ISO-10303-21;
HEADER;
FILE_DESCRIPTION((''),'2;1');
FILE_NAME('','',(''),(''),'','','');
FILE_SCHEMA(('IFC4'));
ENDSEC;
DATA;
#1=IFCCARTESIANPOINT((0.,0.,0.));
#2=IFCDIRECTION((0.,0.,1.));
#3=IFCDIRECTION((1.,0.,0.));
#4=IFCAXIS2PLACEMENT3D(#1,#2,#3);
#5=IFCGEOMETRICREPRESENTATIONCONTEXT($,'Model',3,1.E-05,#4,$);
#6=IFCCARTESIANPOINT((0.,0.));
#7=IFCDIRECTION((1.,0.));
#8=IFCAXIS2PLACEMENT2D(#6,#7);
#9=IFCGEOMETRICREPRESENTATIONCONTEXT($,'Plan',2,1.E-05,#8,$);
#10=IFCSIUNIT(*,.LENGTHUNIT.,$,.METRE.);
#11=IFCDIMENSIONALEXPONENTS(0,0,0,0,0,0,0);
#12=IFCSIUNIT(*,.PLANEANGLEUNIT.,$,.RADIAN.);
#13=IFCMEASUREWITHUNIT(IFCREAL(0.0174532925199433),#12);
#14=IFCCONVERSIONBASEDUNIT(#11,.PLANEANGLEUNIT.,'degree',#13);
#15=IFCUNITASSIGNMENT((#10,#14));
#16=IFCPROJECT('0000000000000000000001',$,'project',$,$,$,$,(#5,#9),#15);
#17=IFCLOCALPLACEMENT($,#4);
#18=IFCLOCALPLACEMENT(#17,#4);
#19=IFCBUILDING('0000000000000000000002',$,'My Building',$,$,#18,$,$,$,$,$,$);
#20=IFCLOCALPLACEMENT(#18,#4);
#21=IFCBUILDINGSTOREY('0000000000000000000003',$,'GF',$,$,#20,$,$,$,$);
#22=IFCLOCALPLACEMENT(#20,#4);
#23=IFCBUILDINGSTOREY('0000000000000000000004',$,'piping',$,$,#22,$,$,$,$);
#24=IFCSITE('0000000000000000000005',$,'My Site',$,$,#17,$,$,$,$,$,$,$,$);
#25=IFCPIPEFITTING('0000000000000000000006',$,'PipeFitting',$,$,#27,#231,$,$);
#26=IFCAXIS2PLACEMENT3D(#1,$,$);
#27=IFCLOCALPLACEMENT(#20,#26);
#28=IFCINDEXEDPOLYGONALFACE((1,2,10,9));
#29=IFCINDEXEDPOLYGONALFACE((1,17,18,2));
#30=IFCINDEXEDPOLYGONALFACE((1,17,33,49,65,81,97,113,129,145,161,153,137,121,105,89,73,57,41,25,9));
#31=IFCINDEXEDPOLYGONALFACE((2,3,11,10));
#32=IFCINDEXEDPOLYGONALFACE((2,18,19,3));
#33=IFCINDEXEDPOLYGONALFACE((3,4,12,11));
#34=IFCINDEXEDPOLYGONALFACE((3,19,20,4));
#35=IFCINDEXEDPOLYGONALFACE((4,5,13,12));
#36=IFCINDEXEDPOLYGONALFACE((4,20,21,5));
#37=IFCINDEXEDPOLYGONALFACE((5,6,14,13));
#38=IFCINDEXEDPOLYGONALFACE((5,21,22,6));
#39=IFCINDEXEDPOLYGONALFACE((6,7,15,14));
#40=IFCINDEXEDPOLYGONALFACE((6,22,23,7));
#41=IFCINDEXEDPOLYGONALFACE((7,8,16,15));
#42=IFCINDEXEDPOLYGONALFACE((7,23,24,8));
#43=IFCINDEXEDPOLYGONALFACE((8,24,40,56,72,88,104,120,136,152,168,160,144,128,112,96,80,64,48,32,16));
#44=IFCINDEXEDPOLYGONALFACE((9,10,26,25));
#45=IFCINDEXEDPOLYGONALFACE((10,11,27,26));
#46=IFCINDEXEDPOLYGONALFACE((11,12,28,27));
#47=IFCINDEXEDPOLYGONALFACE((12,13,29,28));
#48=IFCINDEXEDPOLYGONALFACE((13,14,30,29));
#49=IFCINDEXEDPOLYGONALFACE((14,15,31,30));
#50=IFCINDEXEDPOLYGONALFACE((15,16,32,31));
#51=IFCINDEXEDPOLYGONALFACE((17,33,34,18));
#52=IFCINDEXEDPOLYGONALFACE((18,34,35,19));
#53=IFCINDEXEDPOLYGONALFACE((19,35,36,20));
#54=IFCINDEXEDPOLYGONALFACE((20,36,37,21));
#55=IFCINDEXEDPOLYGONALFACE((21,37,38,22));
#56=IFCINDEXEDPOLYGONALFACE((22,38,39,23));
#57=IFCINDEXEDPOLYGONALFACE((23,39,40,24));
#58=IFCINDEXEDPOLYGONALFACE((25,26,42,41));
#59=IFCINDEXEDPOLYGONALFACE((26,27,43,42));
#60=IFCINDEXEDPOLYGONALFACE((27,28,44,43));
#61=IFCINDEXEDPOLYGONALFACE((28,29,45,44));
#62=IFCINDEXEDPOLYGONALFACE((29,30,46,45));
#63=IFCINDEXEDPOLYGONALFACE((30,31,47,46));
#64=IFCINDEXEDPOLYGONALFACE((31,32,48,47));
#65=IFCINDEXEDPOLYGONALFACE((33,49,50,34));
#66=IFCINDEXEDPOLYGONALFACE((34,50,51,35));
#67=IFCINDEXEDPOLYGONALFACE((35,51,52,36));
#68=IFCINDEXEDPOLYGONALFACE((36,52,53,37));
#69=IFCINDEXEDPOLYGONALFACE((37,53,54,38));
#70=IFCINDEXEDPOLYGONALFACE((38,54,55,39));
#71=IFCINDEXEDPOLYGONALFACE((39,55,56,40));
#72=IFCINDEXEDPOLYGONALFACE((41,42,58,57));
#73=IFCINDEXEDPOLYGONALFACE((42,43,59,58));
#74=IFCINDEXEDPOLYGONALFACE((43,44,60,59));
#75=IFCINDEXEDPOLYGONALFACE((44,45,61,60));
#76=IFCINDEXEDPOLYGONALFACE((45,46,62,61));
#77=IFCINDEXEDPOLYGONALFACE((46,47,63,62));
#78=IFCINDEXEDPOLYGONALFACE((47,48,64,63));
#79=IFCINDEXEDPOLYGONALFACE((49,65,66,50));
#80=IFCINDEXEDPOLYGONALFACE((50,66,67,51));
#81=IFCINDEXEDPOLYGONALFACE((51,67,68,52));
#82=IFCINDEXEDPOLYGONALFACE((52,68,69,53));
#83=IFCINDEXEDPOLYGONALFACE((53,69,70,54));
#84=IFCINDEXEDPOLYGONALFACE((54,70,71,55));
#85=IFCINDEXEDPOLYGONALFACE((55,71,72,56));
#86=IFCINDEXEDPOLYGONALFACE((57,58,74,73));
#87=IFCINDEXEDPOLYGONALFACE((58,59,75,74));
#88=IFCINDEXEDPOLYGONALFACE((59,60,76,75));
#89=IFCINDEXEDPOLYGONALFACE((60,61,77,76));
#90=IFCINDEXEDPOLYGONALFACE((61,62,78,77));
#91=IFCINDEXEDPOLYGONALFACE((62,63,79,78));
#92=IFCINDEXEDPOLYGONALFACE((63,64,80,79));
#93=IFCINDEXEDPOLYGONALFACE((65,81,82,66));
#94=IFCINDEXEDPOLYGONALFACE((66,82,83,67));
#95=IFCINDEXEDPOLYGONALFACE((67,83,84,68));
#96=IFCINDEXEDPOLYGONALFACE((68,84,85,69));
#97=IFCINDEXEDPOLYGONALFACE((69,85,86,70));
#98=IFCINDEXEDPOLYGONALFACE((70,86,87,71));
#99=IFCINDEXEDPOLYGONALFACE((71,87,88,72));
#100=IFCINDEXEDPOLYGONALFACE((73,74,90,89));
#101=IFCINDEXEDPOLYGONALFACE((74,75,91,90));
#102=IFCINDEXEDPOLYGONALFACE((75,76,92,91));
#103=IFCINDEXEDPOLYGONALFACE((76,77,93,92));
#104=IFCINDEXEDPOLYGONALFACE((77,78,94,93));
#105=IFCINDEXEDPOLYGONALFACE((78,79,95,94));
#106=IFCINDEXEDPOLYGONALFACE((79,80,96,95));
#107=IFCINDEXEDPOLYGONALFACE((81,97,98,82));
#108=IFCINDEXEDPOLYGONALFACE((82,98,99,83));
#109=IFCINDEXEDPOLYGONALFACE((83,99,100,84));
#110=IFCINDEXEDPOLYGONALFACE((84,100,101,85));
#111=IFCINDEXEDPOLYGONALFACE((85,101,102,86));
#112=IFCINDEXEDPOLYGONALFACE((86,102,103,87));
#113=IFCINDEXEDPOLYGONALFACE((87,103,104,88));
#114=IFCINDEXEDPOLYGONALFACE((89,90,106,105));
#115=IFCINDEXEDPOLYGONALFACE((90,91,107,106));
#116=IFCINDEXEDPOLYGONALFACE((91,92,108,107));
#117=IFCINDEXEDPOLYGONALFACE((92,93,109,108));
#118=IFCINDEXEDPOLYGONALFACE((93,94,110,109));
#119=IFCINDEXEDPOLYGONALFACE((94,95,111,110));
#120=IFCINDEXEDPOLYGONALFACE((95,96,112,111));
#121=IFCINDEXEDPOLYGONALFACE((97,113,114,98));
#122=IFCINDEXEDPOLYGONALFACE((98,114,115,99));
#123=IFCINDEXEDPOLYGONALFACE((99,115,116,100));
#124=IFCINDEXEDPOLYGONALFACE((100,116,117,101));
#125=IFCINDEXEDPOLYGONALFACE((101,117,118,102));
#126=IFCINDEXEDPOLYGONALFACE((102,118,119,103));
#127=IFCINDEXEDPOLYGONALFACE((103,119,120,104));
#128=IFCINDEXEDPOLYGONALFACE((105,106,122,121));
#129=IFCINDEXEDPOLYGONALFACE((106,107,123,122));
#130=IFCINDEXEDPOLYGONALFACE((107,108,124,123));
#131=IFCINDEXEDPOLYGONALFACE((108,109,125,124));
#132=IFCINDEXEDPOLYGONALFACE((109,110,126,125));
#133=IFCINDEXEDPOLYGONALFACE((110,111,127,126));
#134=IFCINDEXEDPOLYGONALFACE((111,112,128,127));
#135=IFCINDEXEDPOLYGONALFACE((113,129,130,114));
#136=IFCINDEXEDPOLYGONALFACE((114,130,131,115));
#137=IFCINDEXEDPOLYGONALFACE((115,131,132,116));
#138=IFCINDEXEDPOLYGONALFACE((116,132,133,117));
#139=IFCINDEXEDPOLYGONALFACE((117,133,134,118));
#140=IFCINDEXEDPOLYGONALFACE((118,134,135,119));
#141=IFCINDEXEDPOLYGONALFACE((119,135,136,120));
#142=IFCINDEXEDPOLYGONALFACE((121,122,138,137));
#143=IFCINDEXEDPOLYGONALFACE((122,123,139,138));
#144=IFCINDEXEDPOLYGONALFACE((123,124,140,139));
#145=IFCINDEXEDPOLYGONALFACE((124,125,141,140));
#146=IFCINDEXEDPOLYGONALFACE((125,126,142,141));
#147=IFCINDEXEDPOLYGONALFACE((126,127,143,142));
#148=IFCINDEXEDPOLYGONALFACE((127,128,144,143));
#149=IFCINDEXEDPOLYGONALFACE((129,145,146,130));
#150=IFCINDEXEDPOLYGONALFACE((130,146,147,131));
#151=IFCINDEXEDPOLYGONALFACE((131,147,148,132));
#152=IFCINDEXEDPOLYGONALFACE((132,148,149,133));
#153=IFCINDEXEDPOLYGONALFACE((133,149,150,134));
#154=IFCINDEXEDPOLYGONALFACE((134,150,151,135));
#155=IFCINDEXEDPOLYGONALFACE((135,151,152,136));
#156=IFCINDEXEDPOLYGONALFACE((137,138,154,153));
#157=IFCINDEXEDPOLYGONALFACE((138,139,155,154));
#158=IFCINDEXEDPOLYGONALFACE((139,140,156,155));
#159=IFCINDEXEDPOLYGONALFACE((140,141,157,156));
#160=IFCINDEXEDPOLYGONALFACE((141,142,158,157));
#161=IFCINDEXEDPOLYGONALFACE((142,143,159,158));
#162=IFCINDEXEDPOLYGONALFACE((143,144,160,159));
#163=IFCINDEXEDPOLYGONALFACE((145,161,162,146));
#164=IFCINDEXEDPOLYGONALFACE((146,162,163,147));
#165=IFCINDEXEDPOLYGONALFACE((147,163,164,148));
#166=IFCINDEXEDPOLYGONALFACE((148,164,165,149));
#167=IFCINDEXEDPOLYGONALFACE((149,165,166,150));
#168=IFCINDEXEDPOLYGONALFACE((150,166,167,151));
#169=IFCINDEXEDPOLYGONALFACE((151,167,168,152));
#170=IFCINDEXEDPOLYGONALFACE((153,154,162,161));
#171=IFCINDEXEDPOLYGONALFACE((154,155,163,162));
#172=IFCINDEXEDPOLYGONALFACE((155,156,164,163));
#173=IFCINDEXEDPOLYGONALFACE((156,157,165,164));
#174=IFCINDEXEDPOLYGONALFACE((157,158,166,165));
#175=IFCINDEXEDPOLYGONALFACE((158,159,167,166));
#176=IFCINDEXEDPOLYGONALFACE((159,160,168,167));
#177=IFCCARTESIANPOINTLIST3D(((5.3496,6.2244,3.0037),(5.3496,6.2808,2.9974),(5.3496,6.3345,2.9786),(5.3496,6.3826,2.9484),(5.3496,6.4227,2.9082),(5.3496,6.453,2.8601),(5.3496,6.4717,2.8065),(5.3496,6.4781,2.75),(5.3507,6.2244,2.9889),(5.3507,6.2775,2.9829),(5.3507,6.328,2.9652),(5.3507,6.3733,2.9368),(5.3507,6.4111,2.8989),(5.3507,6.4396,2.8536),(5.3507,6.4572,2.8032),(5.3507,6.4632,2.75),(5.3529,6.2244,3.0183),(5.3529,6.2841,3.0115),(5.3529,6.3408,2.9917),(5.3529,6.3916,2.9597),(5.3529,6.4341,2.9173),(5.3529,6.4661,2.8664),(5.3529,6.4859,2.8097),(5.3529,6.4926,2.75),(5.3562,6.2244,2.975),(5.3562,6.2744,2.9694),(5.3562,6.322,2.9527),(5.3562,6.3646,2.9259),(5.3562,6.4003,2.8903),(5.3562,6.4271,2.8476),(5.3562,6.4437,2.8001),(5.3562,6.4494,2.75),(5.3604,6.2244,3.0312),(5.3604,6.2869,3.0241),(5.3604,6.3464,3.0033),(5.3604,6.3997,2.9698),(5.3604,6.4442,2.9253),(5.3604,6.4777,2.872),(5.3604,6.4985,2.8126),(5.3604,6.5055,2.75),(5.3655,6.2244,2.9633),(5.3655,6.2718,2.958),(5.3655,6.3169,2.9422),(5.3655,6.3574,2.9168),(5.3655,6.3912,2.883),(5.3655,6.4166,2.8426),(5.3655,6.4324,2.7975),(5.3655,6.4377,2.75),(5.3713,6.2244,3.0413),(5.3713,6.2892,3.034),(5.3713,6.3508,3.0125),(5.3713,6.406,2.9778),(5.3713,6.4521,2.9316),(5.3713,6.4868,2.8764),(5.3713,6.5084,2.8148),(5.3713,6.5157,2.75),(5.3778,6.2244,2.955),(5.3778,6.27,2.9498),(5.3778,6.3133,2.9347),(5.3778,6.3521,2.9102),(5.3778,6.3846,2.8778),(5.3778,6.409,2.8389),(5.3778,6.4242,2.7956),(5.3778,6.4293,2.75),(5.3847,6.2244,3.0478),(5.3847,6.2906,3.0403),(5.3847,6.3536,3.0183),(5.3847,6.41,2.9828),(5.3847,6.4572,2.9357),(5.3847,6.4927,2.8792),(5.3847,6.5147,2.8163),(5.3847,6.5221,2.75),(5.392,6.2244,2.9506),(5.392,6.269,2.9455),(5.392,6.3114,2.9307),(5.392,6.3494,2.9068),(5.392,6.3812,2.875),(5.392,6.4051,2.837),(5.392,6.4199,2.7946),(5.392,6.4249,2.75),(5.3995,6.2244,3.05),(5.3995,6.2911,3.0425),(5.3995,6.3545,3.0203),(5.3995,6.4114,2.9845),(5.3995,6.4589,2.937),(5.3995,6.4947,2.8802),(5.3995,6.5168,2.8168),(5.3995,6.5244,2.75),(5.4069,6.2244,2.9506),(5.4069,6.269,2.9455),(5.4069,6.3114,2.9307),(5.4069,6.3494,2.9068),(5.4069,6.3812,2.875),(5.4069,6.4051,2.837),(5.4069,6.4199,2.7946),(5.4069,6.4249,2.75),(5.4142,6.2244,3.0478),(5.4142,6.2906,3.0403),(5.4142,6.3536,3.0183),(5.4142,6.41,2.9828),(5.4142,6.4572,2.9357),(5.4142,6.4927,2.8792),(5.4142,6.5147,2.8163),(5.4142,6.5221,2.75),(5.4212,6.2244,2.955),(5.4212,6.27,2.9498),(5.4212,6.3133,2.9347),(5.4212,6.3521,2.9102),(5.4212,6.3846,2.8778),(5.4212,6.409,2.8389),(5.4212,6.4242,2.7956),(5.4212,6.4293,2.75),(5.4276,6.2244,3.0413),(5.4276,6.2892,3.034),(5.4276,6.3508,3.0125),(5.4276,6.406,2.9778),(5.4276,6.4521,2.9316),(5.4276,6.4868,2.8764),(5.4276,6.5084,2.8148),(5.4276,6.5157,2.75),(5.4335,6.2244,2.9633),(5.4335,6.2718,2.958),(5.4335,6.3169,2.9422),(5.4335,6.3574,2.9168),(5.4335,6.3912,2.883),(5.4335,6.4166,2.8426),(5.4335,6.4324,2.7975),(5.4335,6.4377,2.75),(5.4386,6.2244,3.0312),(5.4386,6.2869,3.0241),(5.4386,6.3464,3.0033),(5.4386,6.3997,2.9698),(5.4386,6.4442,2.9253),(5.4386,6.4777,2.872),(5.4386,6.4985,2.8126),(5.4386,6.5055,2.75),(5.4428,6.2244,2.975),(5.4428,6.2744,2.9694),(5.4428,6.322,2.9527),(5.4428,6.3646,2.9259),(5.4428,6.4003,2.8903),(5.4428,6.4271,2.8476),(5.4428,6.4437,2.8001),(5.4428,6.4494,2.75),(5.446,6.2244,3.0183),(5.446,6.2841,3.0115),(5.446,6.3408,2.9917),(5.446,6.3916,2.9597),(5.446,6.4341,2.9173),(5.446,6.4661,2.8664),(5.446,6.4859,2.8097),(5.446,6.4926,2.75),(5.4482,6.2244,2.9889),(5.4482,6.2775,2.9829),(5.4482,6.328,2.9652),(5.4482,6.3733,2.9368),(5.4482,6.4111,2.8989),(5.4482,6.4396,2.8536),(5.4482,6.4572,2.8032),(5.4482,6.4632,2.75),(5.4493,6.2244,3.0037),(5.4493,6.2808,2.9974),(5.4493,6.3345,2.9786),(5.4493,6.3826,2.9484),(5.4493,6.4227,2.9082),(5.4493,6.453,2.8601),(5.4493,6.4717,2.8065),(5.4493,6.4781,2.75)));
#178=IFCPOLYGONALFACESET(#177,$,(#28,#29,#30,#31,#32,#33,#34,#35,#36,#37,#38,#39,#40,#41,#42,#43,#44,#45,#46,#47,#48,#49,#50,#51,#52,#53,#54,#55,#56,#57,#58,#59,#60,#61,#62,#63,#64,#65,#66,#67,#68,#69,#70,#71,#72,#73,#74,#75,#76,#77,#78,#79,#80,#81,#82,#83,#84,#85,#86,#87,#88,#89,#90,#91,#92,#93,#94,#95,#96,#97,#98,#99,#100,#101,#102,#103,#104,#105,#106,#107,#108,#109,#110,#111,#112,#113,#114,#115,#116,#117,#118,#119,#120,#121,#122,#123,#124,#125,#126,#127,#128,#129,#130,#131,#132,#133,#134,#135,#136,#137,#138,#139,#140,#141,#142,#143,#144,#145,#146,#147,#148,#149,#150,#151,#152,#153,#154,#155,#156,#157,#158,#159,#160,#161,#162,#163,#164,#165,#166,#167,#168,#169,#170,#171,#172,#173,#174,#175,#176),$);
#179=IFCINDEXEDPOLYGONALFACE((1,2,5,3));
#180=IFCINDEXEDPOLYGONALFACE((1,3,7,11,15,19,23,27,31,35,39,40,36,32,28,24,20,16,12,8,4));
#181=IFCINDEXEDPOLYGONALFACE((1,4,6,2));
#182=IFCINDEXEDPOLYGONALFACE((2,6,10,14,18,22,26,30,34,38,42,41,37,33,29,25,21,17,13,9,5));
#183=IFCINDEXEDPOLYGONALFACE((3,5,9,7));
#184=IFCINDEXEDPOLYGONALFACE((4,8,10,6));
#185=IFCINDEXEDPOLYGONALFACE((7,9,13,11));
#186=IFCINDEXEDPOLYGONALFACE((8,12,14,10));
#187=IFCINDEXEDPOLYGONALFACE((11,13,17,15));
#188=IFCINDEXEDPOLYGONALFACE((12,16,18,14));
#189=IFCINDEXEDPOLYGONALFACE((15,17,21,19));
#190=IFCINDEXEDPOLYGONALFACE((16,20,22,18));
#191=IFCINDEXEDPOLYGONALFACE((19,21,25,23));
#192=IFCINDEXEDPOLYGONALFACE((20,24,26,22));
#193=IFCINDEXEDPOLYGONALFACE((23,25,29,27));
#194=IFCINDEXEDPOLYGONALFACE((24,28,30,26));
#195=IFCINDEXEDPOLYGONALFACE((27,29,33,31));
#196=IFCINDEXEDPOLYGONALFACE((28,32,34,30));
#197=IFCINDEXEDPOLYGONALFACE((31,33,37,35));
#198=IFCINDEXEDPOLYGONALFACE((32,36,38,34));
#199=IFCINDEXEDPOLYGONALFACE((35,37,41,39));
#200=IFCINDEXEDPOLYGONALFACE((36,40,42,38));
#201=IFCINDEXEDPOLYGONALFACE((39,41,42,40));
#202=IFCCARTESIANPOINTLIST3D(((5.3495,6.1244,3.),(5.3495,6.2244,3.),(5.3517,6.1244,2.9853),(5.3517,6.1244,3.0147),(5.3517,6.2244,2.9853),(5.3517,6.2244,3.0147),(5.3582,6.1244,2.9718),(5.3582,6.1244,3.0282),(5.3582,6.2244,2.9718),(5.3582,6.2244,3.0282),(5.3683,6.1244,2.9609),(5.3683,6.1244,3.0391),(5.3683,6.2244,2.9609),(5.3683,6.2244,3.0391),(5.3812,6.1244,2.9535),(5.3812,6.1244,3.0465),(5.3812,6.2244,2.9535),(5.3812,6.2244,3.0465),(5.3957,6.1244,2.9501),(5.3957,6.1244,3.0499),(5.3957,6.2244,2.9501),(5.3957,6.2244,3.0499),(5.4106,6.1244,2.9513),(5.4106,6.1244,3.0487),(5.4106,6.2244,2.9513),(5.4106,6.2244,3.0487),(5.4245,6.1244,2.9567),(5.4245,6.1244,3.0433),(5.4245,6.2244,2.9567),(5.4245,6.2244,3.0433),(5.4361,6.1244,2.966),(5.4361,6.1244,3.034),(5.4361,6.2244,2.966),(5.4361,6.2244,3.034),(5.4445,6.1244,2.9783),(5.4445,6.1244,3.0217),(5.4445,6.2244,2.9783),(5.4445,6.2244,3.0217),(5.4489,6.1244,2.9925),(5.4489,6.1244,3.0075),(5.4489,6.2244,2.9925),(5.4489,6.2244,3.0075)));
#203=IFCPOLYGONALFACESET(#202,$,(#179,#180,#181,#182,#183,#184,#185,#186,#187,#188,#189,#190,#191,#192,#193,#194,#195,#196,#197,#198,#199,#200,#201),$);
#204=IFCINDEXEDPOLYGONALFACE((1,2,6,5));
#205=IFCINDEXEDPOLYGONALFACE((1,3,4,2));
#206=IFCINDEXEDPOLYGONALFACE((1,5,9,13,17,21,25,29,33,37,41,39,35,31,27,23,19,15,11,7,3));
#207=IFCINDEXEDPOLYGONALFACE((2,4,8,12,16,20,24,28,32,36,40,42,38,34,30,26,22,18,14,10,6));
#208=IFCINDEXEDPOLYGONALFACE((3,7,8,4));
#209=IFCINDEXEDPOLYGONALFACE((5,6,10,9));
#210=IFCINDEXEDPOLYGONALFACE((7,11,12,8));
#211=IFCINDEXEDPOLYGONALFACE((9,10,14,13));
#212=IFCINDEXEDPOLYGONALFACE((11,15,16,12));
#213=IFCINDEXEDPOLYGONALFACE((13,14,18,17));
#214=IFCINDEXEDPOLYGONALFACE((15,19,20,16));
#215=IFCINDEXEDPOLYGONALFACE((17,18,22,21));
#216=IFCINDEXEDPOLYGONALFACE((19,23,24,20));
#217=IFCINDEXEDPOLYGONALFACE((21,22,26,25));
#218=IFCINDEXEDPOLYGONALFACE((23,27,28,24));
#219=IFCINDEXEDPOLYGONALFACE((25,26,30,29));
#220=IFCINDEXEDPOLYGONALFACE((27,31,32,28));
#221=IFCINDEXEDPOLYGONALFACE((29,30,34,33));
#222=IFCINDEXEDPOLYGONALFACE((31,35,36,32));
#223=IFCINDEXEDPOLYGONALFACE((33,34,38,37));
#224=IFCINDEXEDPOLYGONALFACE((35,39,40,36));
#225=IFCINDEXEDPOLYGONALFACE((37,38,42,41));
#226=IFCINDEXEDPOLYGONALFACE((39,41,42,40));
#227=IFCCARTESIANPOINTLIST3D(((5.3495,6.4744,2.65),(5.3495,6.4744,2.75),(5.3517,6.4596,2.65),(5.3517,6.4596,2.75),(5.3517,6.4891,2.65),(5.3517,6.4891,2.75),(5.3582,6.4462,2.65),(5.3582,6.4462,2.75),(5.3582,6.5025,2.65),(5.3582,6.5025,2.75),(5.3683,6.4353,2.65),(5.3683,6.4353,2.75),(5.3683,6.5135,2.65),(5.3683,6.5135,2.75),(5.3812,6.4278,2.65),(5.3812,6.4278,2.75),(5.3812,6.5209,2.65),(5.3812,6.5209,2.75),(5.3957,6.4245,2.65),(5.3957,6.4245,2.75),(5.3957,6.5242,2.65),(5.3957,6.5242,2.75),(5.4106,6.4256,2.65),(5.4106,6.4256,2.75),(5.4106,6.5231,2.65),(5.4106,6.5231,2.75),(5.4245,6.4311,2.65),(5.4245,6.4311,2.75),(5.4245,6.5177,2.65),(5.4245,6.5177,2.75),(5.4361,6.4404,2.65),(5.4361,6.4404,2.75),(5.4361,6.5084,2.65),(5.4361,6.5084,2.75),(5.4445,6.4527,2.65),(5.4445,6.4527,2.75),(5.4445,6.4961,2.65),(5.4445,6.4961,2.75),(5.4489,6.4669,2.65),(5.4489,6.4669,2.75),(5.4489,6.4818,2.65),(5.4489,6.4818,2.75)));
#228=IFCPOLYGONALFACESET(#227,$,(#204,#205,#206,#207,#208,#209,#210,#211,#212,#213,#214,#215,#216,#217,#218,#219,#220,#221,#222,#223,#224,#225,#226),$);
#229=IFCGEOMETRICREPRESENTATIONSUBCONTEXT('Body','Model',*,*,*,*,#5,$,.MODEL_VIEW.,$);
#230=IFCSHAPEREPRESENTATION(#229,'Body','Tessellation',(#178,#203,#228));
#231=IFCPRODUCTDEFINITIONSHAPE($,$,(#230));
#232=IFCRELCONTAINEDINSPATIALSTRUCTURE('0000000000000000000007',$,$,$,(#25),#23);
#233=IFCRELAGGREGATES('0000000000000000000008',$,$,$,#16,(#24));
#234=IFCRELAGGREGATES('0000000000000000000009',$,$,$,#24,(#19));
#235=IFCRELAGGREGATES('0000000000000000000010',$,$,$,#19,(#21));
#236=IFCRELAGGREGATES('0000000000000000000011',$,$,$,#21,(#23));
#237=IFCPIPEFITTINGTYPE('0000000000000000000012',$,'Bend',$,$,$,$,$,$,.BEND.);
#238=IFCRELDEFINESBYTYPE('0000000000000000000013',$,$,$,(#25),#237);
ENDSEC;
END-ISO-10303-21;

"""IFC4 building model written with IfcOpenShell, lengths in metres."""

from ifc_helpers import new_model, entity, si_unit, converted_unit, frame, origin_with_axes, origin_2d_with_axis, place, context, subcontext, project, spatial, circle, extrude, source, transform, mapped, type_object, type_shapes, element, save


model = new_model("IFC4")

# Units and contexts
model_context = context("Model", 3, precision=1e-05, world=origin_with_axes())
plan_context = context("Plan", 2, precision=1e-05, world=origin_2d_with_axis())
body_context = subcontext(model_context, "Body", "Model", "MODEL_VIEW")
ifc_project = project(units=[si_unit("LENGTHUNIT", "METRE"), converted_unit("PLANEANGLEUNIT", "degree", entity("IfcReal", 0.0174532925199433), si_unit("PLANEANGLEUNIT", "RADIAN"), dimensions=[0, 0, 0, 0, 0, 0, 0])], contexts=[model_context, plan_context])

# Site, building, storeys
site_placement = place(None, origin_with_axes())
site = spatial("IfcSite", under=ifc_project, at=site_placement, Name="My Site")
building_placement = place(site_placement, origin_with_axes())
building = spatial("IfcBuilding", under=site, at=building_placement, Name="My Building")
storey_1_placement = place(building_placement, origin_with_axes())
storey_1 = spatial("IfcBuildingStorey", under=building, at=storey_1_placement, Name="GF")
storey_2_placement = place(storey_1_placement, origin_with_axes())
storey_2 = spatial("IfcBuildingStorey", under=storey_1, at=storey_2_placement, Name="piping")

# Pipe fitting
pipe_fitting_type = type_object("IfcPipeFittingType", Name="Bend", PredefinedType="BEND")
shared_shape = source(origin_with_axes(), body_context, "Body", "SolidModel", [
    entity("IfcSweptDiskSolid", entity("IfcIndexedPolyCurve", entity("IfcCartesianPointList3D", [[0.0, 0.0, 0.1], [0.0, -0.0732, 0.2768], [0.0, -0.25, 0.35]]), [entity("IfcArcIndex", [1, 2, 3])]), 0.05),
    extrude(circle(Radius=0.05), origin_with_axes(), (0.0, 0.0, 1.0), 0.1),
    extrude(circle(Radius=0.05), frame((0.0, -0.25, 0.35), z_axis=(0.0, -1.0, 0.0), x_axis=(1.0, 0.0, 0.0)), (0.0, 0.0, 1.0), 0.1),
])
type_shapes(pipe_fitting_type, [shared_shape])
for number, where, z_axis, x_axis, name in (
    (1, (5.3995, 6.1244, 3.0), (0.0, 1.0, 0.0), (-1.0, 0.0, 0.0), "PipeFitting"),
):
    element("IfcPipeFitting", number, at=place(storey_2_placement, frame(where, z_axis=z_axis, x_axis=x_axis)), inside=storey_2, type_object=pipe_fitting_type, Name=name, context=body_context, shape_type="MappedRepresentation", body=[
        mapped(shared_shape, transform((0.0, 0.0, 0.0), x_axis=(1.0, 0.0, 0.0), y_axis=(0.0, 1.0, 0.0), z_axis=(0.0, 0.0, 1.0), scale=1.0)),
    ])

save(model, "model.ifc")
